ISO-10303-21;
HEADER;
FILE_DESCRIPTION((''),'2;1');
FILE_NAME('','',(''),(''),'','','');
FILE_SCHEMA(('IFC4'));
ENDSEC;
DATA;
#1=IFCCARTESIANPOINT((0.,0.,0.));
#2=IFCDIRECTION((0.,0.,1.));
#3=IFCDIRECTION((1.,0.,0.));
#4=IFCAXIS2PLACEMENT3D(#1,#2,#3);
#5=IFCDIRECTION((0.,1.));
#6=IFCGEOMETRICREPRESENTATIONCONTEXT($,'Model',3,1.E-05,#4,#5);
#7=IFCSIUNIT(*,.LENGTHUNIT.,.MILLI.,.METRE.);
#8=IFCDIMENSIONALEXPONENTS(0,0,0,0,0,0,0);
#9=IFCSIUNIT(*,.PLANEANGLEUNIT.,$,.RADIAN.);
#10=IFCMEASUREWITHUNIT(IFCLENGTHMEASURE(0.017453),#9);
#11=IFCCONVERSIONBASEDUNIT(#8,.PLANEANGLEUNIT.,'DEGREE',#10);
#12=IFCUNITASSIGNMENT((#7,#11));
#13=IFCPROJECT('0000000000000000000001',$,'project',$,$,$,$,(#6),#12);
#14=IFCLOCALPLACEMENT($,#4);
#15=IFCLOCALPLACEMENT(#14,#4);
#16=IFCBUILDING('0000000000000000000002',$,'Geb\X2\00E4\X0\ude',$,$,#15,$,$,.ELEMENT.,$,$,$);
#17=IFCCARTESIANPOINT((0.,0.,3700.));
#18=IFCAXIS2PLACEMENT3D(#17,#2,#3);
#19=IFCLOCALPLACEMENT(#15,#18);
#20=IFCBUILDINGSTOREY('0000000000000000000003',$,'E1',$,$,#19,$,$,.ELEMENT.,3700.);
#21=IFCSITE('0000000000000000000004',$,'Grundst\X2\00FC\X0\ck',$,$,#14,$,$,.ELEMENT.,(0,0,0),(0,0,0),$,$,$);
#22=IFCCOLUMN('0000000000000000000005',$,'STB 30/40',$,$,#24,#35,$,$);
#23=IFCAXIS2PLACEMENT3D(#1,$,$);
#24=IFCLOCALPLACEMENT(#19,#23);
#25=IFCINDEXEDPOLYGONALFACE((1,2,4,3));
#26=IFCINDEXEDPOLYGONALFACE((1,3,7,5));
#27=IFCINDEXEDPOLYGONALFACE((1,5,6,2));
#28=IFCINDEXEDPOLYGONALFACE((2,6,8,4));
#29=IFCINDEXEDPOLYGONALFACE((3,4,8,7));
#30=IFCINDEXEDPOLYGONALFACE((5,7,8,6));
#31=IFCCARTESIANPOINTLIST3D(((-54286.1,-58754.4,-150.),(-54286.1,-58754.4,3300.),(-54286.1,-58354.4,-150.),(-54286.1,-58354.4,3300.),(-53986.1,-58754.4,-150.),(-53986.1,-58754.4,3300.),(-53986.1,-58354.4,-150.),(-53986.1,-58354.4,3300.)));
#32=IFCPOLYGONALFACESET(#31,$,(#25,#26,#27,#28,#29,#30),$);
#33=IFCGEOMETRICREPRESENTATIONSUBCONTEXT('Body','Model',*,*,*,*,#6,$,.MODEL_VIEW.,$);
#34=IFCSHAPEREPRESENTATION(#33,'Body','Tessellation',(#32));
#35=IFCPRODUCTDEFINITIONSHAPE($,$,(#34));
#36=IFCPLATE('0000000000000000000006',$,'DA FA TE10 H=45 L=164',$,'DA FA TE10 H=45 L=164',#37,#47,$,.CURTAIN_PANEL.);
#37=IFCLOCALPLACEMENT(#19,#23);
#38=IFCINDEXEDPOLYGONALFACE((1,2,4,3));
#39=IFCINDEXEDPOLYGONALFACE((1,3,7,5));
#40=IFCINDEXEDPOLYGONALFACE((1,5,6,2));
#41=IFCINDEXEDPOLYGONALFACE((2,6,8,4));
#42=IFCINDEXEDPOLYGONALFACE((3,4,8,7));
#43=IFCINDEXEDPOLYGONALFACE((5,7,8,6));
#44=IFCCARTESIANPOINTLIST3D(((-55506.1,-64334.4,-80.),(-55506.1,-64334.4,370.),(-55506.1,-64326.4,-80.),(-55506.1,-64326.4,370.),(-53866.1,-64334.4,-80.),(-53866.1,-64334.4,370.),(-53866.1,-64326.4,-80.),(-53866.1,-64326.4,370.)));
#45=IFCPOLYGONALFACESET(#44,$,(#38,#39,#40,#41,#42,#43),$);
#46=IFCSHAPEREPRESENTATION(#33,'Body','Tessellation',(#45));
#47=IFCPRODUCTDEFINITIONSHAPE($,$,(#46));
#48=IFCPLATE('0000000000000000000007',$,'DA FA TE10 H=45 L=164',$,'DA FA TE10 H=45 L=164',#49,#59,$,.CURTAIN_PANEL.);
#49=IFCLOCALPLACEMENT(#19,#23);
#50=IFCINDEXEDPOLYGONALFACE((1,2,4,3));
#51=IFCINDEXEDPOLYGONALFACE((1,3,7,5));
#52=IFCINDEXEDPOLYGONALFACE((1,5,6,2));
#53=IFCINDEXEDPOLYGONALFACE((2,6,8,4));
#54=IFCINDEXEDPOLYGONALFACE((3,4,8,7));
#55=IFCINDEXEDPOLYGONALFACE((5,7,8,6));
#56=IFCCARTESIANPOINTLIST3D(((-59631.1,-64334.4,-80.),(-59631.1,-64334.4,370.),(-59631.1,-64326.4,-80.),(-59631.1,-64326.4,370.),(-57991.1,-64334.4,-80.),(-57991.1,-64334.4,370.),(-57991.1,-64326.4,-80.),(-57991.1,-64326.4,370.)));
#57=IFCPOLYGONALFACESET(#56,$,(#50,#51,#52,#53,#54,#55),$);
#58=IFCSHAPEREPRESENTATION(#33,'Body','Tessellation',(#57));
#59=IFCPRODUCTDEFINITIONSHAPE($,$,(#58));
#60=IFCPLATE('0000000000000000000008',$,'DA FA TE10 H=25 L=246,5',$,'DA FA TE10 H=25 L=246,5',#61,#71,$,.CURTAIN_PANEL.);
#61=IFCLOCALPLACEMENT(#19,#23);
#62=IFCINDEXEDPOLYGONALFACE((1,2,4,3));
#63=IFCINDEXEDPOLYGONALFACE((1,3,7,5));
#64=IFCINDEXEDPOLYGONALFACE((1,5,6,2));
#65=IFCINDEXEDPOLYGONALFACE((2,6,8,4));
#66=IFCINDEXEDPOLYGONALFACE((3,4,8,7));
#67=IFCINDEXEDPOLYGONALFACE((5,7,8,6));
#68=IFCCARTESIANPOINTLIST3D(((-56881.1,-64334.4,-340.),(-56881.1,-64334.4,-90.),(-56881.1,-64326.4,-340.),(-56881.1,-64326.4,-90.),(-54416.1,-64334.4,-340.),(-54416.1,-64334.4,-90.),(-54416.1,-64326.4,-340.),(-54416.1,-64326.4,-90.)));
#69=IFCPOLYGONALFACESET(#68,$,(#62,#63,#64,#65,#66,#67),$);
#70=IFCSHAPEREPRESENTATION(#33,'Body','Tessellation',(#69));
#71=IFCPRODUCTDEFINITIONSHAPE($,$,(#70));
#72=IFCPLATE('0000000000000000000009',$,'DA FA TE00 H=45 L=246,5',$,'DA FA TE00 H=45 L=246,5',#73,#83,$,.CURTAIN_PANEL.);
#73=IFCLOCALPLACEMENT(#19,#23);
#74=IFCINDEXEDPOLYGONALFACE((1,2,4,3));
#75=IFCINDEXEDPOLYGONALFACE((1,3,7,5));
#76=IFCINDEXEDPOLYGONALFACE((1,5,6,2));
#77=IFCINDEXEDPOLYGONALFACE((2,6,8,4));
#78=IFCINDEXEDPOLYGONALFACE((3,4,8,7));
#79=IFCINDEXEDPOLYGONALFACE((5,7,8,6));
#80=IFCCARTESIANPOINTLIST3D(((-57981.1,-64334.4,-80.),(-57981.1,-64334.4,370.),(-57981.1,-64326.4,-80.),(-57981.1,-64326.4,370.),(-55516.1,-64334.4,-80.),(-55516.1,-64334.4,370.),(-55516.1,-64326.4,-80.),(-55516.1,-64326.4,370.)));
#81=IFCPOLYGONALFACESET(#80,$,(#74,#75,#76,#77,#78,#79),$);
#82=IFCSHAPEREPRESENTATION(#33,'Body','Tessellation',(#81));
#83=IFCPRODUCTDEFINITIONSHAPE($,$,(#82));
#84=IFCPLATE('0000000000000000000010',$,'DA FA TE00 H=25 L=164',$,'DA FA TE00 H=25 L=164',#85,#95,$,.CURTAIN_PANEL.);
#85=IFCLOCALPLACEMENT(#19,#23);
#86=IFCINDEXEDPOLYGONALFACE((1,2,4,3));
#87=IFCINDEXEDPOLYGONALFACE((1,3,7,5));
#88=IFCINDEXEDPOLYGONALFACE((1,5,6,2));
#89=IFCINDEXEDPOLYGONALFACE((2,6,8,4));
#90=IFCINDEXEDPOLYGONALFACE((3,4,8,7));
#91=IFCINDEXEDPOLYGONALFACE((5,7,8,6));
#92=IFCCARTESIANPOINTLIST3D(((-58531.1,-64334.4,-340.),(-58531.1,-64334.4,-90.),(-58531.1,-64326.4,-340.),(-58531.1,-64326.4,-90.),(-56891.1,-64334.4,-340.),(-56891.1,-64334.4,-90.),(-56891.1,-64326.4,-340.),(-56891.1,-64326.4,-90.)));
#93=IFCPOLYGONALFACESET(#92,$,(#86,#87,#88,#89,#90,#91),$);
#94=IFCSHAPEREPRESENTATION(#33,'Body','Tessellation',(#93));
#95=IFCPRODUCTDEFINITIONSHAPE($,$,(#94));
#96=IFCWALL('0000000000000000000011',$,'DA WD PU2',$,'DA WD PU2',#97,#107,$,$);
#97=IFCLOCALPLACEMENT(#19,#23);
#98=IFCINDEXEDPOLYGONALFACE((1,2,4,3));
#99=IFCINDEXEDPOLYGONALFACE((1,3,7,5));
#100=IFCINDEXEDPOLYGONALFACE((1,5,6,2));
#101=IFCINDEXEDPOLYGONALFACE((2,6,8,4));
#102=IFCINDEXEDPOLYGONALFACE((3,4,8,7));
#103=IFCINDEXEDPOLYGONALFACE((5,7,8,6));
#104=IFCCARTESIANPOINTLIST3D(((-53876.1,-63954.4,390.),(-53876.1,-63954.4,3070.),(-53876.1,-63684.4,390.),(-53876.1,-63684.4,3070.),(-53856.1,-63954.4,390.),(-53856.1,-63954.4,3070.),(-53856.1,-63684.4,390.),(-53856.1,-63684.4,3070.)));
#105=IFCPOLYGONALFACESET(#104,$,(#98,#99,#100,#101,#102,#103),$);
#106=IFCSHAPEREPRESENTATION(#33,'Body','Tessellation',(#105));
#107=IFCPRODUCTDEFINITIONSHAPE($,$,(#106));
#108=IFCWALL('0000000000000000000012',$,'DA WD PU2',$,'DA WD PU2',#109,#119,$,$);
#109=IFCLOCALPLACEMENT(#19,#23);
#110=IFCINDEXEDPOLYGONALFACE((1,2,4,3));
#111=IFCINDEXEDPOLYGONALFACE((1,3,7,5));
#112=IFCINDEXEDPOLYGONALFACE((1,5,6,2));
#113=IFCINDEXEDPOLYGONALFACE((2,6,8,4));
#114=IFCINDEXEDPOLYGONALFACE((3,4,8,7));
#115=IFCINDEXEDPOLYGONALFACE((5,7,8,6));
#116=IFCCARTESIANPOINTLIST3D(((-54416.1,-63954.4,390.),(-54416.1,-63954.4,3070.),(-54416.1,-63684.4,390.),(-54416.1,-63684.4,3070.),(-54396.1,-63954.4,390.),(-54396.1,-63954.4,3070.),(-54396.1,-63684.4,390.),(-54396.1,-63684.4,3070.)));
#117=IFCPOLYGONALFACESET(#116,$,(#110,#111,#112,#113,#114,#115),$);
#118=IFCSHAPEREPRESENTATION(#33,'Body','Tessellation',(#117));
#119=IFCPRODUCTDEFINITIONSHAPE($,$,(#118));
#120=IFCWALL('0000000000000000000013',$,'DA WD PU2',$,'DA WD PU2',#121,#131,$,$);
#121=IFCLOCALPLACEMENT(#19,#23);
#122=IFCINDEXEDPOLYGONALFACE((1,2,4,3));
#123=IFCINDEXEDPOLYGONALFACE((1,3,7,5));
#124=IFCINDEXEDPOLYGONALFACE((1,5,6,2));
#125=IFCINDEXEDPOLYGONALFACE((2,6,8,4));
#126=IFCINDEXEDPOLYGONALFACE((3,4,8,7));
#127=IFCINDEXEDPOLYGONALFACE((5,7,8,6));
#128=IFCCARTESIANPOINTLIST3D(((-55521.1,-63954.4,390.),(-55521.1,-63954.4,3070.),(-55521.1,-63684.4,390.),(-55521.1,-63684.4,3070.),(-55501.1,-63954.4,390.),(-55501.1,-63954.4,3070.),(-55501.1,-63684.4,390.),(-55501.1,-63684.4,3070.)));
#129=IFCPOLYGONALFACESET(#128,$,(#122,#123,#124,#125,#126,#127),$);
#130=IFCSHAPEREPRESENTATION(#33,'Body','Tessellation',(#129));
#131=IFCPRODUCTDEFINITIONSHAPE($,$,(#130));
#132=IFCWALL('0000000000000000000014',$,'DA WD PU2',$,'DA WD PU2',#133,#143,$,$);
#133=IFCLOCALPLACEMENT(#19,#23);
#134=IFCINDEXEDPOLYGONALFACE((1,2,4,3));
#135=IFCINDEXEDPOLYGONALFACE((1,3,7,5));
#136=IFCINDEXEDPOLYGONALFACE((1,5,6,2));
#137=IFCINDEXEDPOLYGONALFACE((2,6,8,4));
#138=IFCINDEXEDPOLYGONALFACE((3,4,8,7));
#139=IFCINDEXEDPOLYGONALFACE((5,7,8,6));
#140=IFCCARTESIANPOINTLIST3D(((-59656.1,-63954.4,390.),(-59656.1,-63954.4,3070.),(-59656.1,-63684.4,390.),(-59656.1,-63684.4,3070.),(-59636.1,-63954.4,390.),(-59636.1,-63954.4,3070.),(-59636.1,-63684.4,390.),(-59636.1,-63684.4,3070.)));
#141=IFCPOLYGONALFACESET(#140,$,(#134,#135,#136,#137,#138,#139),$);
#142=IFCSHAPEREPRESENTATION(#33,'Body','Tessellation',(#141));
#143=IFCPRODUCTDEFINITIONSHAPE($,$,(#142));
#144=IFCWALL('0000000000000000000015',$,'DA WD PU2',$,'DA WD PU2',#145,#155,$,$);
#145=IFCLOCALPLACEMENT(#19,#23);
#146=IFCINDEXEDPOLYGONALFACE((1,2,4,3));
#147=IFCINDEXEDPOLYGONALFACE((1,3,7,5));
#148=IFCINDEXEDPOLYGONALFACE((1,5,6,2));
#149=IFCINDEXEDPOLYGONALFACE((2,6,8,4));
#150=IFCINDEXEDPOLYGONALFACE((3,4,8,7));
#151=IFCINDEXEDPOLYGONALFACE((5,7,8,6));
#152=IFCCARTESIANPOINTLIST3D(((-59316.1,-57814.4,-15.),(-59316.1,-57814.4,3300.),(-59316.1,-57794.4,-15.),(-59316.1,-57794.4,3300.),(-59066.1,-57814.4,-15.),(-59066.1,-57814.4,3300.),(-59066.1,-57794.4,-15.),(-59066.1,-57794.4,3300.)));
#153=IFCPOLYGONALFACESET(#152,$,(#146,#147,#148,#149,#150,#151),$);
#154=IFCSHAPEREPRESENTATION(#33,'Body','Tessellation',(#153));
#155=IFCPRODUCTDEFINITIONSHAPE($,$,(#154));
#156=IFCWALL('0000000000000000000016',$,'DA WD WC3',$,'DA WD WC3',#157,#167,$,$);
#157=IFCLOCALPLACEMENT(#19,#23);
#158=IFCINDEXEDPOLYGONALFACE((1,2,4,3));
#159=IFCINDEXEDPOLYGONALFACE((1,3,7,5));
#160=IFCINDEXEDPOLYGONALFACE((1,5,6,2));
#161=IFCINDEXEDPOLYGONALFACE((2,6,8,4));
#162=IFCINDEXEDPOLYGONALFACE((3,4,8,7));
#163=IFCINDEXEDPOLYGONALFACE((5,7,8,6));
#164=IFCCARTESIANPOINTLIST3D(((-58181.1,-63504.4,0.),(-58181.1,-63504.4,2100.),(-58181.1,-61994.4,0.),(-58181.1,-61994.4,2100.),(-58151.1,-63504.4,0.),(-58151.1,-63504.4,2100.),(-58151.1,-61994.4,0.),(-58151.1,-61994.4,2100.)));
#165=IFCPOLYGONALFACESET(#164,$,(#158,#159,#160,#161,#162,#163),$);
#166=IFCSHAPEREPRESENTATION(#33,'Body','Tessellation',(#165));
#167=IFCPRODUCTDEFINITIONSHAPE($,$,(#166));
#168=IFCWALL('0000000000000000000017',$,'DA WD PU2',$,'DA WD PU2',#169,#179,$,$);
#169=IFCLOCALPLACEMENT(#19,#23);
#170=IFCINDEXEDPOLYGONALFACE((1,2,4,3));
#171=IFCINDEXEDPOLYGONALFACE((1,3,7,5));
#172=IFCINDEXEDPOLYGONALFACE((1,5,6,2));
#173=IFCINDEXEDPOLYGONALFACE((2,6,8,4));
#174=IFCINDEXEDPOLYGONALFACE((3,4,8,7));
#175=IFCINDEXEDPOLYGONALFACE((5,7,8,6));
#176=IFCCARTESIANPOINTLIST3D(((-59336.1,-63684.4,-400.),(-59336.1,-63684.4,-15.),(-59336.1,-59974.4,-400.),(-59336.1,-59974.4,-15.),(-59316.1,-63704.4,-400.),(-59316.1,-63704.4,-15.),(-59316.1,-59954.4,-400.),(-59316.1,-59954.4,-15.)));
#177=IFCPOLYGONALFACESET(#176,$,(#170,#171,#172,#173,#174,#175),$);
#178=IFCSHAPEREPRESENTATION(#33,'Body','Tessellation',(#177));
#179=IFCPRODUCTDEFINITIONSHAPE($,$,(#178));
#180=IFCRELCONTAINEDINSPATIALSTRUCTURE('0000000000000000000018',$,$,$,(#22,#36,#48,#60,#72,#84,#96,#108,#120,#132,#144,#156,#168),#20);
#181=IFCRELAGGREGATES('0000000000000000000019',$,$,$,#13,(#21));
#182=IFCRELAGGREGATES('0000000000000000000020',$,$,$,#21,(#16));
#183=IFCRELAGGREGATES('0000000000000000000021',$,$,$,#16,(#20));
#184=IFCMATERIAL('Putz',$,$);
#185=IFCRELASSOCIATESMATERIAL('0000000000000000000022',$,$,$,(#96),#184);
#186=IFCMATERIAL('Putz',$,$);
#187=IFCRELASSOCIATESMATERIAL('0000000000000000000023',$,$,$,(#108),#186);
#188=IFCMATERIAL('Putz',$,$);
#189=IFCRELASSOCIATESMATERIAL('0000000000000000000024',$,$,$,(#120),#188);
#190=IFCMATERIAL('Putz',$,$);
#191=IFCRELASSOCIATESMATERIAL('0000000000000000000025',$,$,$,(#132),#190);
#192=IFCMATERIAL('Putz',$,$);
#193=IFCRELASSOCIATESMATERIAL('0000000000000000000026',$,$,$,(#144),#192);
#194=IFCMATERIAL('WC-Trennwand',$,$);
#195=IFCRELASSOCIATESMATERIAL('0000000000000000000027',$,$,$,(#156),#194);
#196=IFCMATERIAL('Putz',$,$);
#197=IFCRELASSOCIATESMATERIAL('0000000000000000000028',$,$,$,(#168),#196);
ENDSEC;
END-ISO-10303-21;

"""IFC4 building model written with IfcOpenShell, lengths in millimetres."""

from ifc_helpers import new_model, entity, si_unit, converted_unit, direction, frame, origin_with_axes, place, context, subcontext, project, spatial, line, indexed_curve, outline, extrude, source, transform, mapped, material, element, save


model = new_model("IFC4")

# Units and contexts
model_context = context("Model", 3, precision=1e-05, world=origin_with_axes(), true_north=direction((0.0, 1.0)))
body_context = subcontext(model_context, "Body", "Model", "MODEL_VIEW")
ifc_project = project(units=[si_unit("LENGTHUNIT", "METRE", prefix="MILLI"), converted_unit("PLANEANGLEUNIT", "DEGREE", entity("IfcLengthMeasure", 0.017453), si_unit("PLANEANGLEUNIT", "RADIAN"), dimensions=[0, 0, 0, 0, 0, 0, 0])], contexts=[model_context])

# Site, building, storey
site_placement = place(None, origin_with_axes())
site = spatial("IfcSite", under=ifc_project, at=site_placement, Name="Grundstück", CompositionType="ELEMENT", RefLatitude=(0, 0, 0), RefLongitude=(0, 0, 0))
building_placement = place(site_placement, origin_with_axes())
building = spatial("IfcBuilding", under=site, at=building_placement, Name="Gebäude", CompositionType="ELEMENT")
storey_placement = place(building_placement, frame((0.0, 0.0, 3700.0), z_axis=(0.0, 0.0, 1.0), x_axis=(1.0, 0.0, 0.0)))
storey = spatial("IfcBuildingStorey", under=building, at=storey_placement, Name="E1", CompositionType="ELEMENT", Elevation=3700.0)

# Column
column_placement = place(storey_placement, frame((-54136.1, -58554.4, -150.0), z_axis=(0.0, 0.0, 1.0), x_axis=(1.0, 0.0, 0.0)))
element("IfcColumn", 1, at=column_placement, inside=storey, Name="STB 30/40", context=body_context, shape_type="SweptSolid", body=[
    extrude(outline(indexed_curve([(-150.0, -200.0), (150.0, -200.0), (150.0, 200.0), (-150.0, 200.0)], segments=[line(1, 2), line(2, 3), line(3, 4), line(4, 1)])), origin_with_axes(), (0.0, 0.0, 1.0), 3450.0),
])

# Plates
shared_shape_1 = source(origin_with_axes(), body_context, "Body", "SweptSolid", [
    extrude(outline(indexed_curve([(-820.0, 0.0), (820.0, 0.0), (820.0, 8.0), (-820.0, 8.0)], segments=[line(1, 2), line(2, 3), line(3, 4), line(4, 1)])), frame((0.0, 0.0, 450.0), z_axis=(0.0, 0.0, 1.0), x_axis=(1.0, 0.0, 0.0)), (0.0, 0.0, -1.0), 450.0),
])
for number, where, z_axis, x_axis, name in (
    (2, (-54686.1, -64334.4, -80.0), (0.0, 0.0, 1.0), (1.0, 0.0, 0.0), "DA FA TE10 H=45 L=164"),
    (3, (-58811.1, -64334.4, -80.0), (0.0, 0.0, 1.0), (1.0, 0.0, 0.0), "DA FA TE10 H=45 L=164"),
):
    element("IfcPlate", number, at=place(storey_placement, frame(where, z_axis=z_axis, x_axis=x_axis)), inside=storey, Name=name, ObjectType="DA FA TE10 H=45 L=164", PredefinedType="CURTAIN_PANEL", context=body_context, shape_type="MappedRepresentation", body=[
        mapped(shared_shape_1, transform((0.0, 0.0, 0.0), x_axis=(1.0, 0.0, 0.0), y_axis=(0.0, 1.0, 0.0), z_axis=(0.0, 0.0, 1.0), scale=1.0)),
    ])
shared_shape_2 = source(origin_with_axes(), body_context, "Body", "SweptSolid", [
    extrude(outline(indexed_curve([(-1232.5, 0.0), (1232.5, 0.0), (1232.5, 8.0), (-1232.5, 8.0)], segments=[line(1, 2), line(2, 3), line(3, 4), line(4, 1)])), frame((0.0, 0.0, 250.0), z_axis=(0.0, 0.0, 1.0), x_axis=(1.0, 0.0, 0.0)), (0.0, 0.0, -1.0), 250.0),
])
plate_1_placement = place(storey_placement, frame((-55648.6, -64334.4, -340.0), z_axis=(0.0, 0.0, 1.0), x_axis=(1.0, 0.0, 0.0)))
element("IfcPlate", 4, at=plate_1_placement, inside=storey, Name="DA FA TE10 H=25 L=246,5", ObjectType="DA FA TE10 H=25 L=246,5", PredefinedType="CURTAIN_PANEL", context=body_context, shape_type="MappedRepresentation", body=[
    mapped(shared_shape_2, transform((0.0, 0.0, 0.0), x_axis=(1.0, 0.0, 0.0), y_axis=(0.0, 1.0, 0.0), z_axis=(0.0, 0.0, 1.0), scale=1.0)),
])
shared_shape_3 = source(origin_with_axes(), body_context, "Body", "SweptSolid", [
    extrude(outline(indexed_curve([(-1232.5, 0.0), (1232.5, 0.0), (1232.5, 8.0), (-1232.5, 8.0)], segments=[line(1, 2), line(2, 3), line(3, 4), line(4, 1)])), frame((0.0, 0.0, 450.0), z_axis=(0.0, 0.0, 1.0), x_axis=(1.0, 0.0, 0.0)), (0.0, 0.0, -1.0), 450.0),
])
plate_2_placement = place(storey_placement, frame((-56748.6, -64334.4, -80.0), z_axis=(0.0, 0.0, 1.0), x_axis=(1.0, 0.0, 0.0)))
element("IfcPlate", 5, at=plate_2_placement, inside=storey, Name="DA FA TE00 H=45 L=246,5", ObjectType="DA FA TE00 H=45 L=246,5", PredefinedType="CURTAIN_PANEL", context=body_context, shape_type="MappedRepresentation", body=[
    mapped(shared_shape_3, transform((0.0, 0.0, 0.0), x_axis=(1.0, 0.0, 0.0), y_axis=(0.0, 1.0, 0.0), z_axis=(0.0, 0.0, 1.0), scale=1.0)),
])
shared_shape_4 = source(origin_with_axes(), body_context, "Body", "SweptSolid", [
    extrude(outline(indexed_curve([(-820.0, 0.0), (820.0, 0.0), (820.0, 8.0), (-820.0, 8.0)], segments=[line(1, 2), line(2, 3), line(3, 4), line(4, 1)])), frame((0.0, 0.0, 250.0), z_axis=(0.0, 0.0, 1.0), x_axis=(1.0, 0.0, 0.0)), (0.0, 0.0, -1.0), 250.0),
])
plate_3_placement = place(storey_placement, frame((-57711.1, -64334.4, -340.0), z_axis=(0.0, 0.0, 1.0), x_axis=(1.0, 0.0, 0.0)))
element("IfcPlate", 6, at=plate_3_placement, inside=storey, Name="DA FA TE00 H=25 L=164", ObjectType="DA FA TE00 H=25 L=164", PredefinedType="CURTAIN_PANEL", context=body_context, shape_type="MappedRepresentation", body=[
    mapped(shared_shape_4, transform((0.0, 0.0, 0.0), x_axis=(1.0, 0.0, 0.0), y_axis=(0.0, 1.0, 0.0), z_axis=(0.0, 0.0, 1.0), scale=1.0)),
])

# Walls
ifc_material_1 = material(Name="Putz")
wall_1_placement = place(storey_placement, frame((-53866.1, -63954.4, 390.0), z_axis=(0.0, 0.0, 1.0), x_axis=(0.0, 1.0, 0.0)))
element("IfcWall", 7, at=wall_1_placement, inside=storey, material=ifc_material_1, Name="DA WD PU2", ObjectType="DA WD PU2", context=body_context, shape_type="SweptSolid", body=[
    extrude(outline(indexed_curve([(0.0, -10.0), (0.0, 10.0), (270.0, 10.0), (270.0, -10.0)], segments=[line(1, 2), line(2, 3), line(3, 4), line(4, 1)])), origin_with_axes(), (0.0, 0.0, 1.0), 2680.0),
])
ifc_material_2 = material(Name="Putz")
wall_2_placement = place(storey_placement, frame((-54406.1, -63684.4, 390.0), z_axis=(0.0, 0.0, 1.0), x_axis=(0.0, -1.0, 0.0)))
element("IfcWall", 8, at=wall_2_placement, inside=storey, material=ifc_material_2, Name="DA WD PU2", ObjectType="DA WD PU2", context=body_context, shape_type="SweptSolid", body=[
    extrude(outline(indexed_curve([(0.0, -10.0), (0.0, 10.0), (270.0, 10.0), (270.0, -10.0)], segments=[line(1, 2), line(2, 3), line(3, 4), line(4, 1)])), origin_with_axes(), (0.0, 0.0, 1.0), 2680.0),
])
ifc_material_3 = material(Name="Putz")
wall_3_placement = place(storey_placement, frame((-55511.1, -63684.4, 390.0), z_axis=(0.0, 0.0, 1.0), x_axis=(0.0, -1.0, 0.0)))
element("IfcWall", 9, at=wall_3_placement, inside=storey, material=ifc_material_3, Name="DA WD PU2", ObjectType="DA WD PU2", context=body_context, shape_type="SweptSolid", body=[
    extrude(outline(indexed_curve([(0.0, -10.0), (0.0, 10.0), (270.0, 10.0), (270.0, -10.0)], segments=[line(1, 2), line(2, 3), line(3, 4), line(4, 1)])), origin_with_axes(), (0.0, 0.0, 1.0), 2680.0),
])
ifc_material_4 = material(Name="Putz")
wall_4_placement = place(storey_placement, frame((-59646.1, -63684.4, 390.0), z_axis=(0.0, 0.0, 1.0), x_axis=(0.0, -1.0, 0.0)))
element("IfcWall", 10, at=wall_4_placement, inside=storey, material=ifc_material_4, Name="DA WD PU2", ObjectType="DA WD PU2", context=body_context, shape_type="SweptSolid", body=[
    extrude(outline(indexed_curve([(0.0, -10.0), (0.0, 10.0), (270.0, 10.0), (270.0, -10.0)], segments=[line(1, 2), line(2, 3), line(3, 4), line(4, 1)])), origin_with_axes(), (0.0, 0.0, 1.0), 2680.0),
])
ifc_material_5 = material(Name="Putz")
wall_5_placement = place(storey_placement, frame((-59316.1, -57804.4, -15.0), z_axis=(0.0, 0.0, 1.0), x_axis=(1.0, 0.0, 0.0)))
element("IfcWall", 11, at=wall_5_placement, inside=storey, material=ifc_material_5, Name="DA WD PU2", ObjectType="DA WD PU2", context=body_context, shape_type="SweptSolid", body=[
    extrude(outline(indexed_curve([(0.0, -10.0), (0.0, 10.0), (250.0, 10.0), (250.0, -10.0)], segments=[line(1, 2), line(2, 3), line(3, 4), line(4, 1)])), origin_with_axes(), (0.0, 0.0, 1.0), 3315.0),
])
ifc_material_6 = material(Name="WC-Trennwand")
wall_6_placement = place(storey_placement, frame((-58166.1, -63504.4, 0.0), z_axis=(0.0, 0.0, 1.0), x_axis=(0.0, 1.0, 0.0)))
element("IfcWall", 12, at=wall_6_placement, inside=storey, material=ifc_material_6, Name="DA WD WC3", ObjectType="DA WD WC3", context=body_context, shape_type="SweptSolid", body=[
    extrude(outline(indexed_curve([(0.0, -15.0), (0.0, 15.0), (1510.0, 15.0), (1510.0, -15.0)], segments=[line(1, 2), line(2, 3), line(3, 4), line(4, 1)])), origin_with_axes(), (0.0, 0.0, 1.0), 2100.0),
])
ifc_material_7 = material(Name="Putz")
wall_7_placement = place(storey_placement, frame((-59326.1, -59964.4, -400.0), z_axis=(0.0, 0.0, 1.0), x_axis=(0.0, -1.0, 0.0)))
element("IfcWall", 13, at=wall_7_placement, inside=storey, material=ifc_material_7, Name="DA WD PU2", ObjectType="DA WD PU2", context=body_context, shape_type="SweptSolid", body=[
    extrude(outline(indexed_curve([(10.0, -10.0), (-10.0, 10.0), (3740.0, 10.0), (3720.0, -10.0)], segments=[line(1, 2), line(2, 3), line(3, 4), line(4, 1)])), origin_with_axes(), (0.0, 0.0, 1.0), 385.0),
])

save(model, "model.ifc")
